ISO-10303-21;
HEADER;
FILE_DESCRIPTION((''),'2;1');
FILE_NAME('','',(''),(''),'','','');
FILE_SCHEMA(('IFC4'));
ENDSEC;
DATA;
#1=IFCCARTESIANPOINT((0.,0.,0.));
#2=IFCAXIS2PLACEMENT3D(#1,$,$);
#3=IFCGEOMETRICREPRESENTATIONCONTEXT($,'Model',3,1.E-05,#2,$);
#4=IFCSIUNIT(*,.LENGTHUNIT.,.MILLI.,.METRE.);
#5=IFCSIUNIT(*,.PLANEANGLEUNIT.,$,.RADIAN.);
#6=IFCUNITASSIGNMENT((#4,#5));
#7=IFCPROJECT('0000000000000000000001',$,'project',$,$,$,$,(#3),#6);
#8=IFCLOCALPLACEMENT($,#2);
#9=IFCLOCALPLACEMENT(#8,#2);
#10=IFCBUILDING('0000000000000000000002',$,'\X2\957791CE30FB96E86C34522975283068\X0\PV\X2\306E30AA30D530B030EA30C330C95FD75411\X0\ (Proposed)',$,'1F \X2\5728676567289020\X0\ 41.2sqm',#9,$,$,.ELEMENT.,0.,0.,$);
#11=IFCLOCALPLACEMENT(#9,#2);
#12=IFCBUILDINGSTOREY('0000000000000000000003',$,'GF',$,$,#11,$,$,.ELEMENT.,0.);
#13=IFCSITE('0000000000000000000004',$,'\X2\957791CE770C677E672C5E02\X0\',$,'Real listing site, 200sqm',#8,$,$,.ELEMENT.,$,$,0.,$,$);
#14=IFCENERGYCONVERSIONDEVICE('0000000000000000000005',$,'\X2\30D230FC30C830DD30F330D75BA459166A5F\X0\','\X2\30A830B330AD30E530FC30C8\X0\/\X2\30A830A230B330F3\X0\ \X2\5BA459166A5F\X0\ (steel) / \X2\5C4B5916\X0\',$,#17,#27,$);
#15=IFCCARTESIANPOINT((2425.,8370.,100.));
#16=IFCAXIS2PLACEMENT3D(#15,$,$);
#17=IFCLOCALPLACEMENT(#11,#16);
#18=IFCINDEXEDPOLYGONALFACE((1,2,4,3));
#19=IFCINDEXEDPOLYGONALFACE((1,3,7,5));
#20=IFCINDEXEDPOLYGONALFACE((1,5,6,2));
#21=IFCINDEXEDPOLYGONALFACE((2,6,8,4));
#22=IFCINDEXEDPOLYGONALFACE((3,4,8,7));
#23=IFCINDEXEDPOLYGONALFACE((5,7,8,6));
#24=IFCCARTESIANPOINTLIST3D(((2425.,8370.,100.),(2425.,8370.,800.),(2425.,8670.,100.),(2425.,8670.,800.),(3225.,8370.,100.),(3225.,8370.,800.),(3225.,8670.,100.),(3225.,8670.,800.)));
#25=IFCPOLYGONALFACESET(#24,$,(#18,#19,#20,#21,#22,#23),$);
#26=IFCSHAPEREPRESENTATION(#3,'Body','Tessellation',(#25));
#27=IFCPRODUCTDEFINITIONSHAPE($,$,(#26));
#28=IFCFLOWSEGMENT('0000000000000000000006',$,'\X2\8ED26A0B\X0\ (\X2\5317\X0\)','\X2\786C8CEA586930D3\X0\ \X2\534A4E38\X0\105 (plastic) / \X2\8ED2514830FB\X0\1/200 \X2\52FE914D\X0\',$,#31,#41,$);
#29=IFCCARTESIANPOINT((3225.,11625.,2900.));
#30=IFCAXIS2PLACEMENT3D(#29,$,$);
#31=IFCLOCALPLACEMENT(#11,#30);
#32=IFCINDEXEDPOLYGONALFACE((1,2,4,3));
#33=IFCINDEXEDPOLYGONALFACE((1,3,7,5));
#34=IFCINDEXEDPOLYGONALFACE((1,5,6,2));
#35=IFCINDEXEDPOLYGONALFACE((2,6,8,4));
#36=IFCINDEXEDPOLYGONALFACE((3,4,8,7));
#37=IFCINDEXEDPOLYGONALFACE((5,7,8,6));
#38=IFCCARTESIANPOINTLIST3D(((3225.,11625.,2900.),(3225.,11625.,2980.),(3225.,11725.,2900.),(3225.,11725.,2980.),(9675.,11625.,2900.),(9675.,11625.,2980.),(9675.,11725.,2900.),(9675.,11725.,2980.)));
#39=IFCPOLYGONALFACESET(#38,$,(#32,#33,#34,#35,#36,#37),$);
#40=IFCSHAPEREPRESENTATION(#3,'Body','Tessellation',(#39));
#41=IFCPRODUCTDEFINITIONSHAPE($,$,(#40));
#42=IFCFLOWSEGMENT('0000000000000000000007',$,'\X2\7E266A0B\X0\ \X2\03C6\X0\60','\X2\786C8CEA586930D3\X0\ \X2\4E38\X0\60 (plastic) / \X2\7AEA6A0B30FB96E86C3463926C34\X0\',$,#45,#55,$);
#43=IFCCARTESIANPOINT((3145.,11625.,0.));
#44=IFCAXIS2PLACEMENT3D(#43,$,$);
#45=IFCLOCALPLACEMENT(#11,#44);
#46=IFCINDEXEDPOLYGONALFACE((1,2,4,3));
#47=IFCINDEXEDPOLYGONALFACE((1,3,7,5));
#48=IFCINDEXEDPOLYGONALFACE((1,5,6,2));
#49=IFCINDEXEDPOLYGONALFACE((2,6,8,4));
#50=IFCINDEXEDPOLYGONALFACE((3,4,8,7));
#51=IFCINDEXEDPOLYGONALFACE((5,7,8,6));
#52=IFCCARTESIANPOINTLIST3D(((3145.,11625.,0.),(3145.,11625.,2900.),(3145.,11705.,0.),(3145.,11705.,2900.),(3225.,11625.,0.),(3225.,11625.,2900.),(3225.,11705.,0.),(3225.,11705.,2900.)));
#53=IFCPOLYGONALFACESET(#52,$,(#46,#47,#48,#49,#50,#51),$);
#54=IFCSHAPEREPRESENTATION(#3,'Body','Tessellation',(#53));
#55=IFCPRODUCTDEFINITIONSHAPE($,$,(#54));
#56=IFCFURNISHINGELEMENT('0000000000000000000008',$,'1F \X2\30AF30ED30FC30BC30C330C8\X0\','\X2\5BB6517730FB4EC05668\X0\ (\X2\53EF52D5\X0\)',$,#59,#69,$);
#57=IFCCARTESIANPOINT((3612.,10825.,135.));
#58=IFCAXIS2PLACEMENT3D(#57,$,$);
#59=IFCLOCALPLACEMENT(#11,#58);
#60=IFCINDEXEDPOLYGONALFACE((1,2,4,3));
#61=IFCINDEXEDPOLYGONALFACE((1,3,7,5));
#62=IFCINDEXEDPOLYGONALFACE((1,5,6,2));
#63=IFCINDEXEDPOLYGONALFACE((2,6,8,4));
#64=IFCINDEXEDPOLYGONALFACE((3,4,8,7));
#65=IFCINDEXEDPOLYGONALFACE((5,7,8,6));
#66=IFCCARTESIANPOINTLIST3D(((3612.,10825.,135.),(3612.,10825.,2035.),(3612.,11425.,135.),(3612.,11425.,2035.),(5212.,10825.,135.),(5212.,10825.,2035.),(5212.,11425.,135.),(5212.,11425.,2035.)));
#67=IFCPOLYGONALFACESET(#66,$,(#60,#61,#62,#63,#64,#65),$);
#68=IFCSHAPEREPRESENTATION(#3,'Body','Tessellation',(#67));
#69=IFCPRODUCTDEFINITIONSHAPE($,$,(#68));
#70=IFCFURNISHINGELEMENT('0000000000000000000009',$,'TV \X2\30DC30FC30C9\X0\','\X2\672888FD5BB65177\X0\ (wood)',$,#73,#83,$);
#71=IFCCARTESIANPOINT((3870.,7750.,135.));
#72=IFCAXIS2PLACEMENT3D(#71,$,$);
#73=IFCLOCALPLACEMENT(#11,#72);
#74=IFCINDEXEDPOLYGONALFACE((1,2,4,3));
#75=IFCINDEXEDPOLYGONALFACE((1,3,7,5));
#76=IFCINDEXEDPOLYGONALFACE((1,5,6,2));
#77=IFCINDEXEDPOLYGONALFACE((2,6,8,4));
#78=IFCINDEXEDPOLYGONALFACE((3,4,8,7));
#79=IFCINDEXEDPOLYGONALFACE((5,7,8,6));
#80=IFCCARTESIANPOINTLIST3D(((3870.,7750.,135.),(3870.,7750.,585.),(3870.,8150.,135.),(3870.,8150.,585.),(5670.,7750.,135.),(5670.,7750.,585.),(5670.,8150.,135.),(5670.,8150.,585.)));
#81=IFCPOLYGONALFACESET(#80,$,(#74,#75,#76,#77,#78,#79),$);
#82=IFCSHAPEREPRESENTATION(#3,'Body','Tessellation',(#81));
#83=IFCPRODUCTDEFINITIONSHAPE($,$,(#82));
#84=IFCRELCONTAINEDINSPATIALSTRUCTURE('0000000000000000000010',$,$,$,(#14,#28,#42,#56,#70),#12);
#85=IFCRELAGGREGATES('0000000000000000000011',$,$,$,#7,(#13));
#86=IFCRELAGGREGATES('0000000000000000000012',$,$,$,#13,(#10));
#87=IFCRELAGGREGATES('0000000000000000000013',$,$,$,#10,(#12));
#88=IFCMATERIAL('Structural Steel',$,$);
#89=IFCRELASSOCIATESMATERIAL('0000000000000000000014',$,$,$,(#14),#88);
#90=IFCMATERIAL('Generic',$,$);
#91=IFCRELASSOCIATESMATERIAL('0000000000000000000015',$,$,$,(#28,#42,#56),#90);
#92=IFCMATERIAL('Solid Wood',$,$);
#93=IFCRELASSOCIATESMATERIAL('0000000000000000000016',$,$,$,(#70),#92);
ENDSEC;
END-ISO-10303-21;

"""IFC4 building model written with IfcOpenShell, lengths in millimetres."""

from ifc_helpers import new_model, si_unit, frame, frame_2d, origin, place, context, project, spatial, rectangle, extrude, material, element, save


model = new_model("IFC4")

# Units and contexts
model_context = context("Model", 3, precision=1e-05, world=origin())
ifc_project = project(units=[si_unit("LENGTHUNIT", "METRE", prefix="MILLI"), si_unit("PLANEANGLEUNIT", "RADIAN")], contexts=[model_context])

# Site, building, storey
site_placement = place(None, origin())
site = spatial("IfcSite", under=ifc_project, at=site_placement, Name="長野県松本市", ObjectType="Real listing site, 200sqm", CompositionType="ELEMENT", RefElevation=0.0)
building_placement = place(site_placement, origin())
building = spatial("IfcBuilding", under=site, at=building_placement, Name="長野・雨水利用とPVのオフグリッド志向 (Proposed)", ObjectType="1F 在来木造 41.2sqm", CompositionType="ELEMENT", ElevationOfRefHeight=0.0, ElevationOfTerrain=0.0)
storey_placement = place(building_placement, origin())
storey = spatial("IfcBuildingStorey", under=building, at=storey_placement, Name="GF", CompositionType="ELEMENT", Elevation=0.0)

# Shared definitions
ifc_material_1 = material(Name="Solid Wood")

# Shared definitions
ifc_material_2 = material(Name="Structural Steel")

# Shared definitions
ifc_material_3 = material(Name="Generic")

# Energy conversion device
energy_conversion_device_placement = place(storey_placement, frame((2425.0, 8370.0, 100.0)))
element("IfcEnergyConversionDevice", 1, at=energy_conversion_device_placement, inside=storey, material=ifc_material_2, Name="ヒートポンプ室外機", Description="エコキュート/エアコン 室外機 (steel) / 屋外", context=model_context, shape_type="SweptSolid", body=[
    extrude(rectangle(XDim=800.0, YDim=300.0, at=frame_2d((400.0, 150.0))), frame((2425.0, 8370.0, 100.0)), (0.0, 0.0, 1.0), 700.0),
])

# Flow segments
flow_segment_1_placement = place(storey_placement, frame((3225.0, 11625.0, 2900.0)))
element("IfcFlowSegment", 2, at=flow_segment_1_placement, inside=storey, material=ifc_material_3, Name="軒樋 (北)", Description="硬質塩ビ 半丸105 (plastic) / 軒先・1/200 勾配", context=model_context, shape_type="SweptSolid", body=[
    extrude(rectangle(XDim=6450.0, YDim=100.0, at=frame_2d((3225.0, 50.0))), frame((3225.0, 11625.0, 2900.0)), (0.0, 0.0, 1.0), 80.0),
])
flow_segment_2_placement = place(storey_placement, frame((3145.0, 11625.0, 0.0)))
element("IfcFlowSegment", 3, at=flow_segment_2_placement, inside=storey, material=ifc_material_3, Name="縦樋 φ60", Description="硬質塩ビ 丸60 (plastic) / 竪樋・雨水排水", context=model_context, shape_type="SweptSolid", body=[
    extrude(rectangle(XDim=80.0, YDim=80.0, at=frame_2d((40.0, 40.0))), frame((3145.0, 11625.0, 0.0)), (0.0, 0.0, 1.0), 2900.0),
])

# Furnishing elements
furnishing_1_placement = place(storey_placement, frame((3612.0, 10825.0, 135.0)))
element("IfcFurnishingElement", 4, at=furnishing_1_placement, inside=storey, material=ifc_material_3, Name="1F クローゼット", Description="家具・什器 (可動)", context=model_context, shape_type="SweptSolid", body=[
    extrude(rectangle(XDim=1600.0, YDim=600.0, at=frame_2d((800.0, 300.0))), frame((3612.0, 10825.0, 135.0)), (0.0, 0.0, 1.0), 1900.0),
])
furnishing_2_placement = place(storey_placement, frame((3870.0, 7750.0, 135.0)))
element("IfcFurnishingElement", 5, at=furnishing_2_placement, inside=storey, material=ifc_material_1, Name="TV ボード", Description="木製家具 (wood)", context=model_context, shape_type="SweptSolid", body=[
    extrude(rectangle(XDim=1800.0, YDim=400.0, at=frame_2d((900.0, 200.0))), frame((3870.0, 7750.0, 135.0)), (0.0, 0.0, 1.0), 450.0),
])

save(model, "model.ifc")
